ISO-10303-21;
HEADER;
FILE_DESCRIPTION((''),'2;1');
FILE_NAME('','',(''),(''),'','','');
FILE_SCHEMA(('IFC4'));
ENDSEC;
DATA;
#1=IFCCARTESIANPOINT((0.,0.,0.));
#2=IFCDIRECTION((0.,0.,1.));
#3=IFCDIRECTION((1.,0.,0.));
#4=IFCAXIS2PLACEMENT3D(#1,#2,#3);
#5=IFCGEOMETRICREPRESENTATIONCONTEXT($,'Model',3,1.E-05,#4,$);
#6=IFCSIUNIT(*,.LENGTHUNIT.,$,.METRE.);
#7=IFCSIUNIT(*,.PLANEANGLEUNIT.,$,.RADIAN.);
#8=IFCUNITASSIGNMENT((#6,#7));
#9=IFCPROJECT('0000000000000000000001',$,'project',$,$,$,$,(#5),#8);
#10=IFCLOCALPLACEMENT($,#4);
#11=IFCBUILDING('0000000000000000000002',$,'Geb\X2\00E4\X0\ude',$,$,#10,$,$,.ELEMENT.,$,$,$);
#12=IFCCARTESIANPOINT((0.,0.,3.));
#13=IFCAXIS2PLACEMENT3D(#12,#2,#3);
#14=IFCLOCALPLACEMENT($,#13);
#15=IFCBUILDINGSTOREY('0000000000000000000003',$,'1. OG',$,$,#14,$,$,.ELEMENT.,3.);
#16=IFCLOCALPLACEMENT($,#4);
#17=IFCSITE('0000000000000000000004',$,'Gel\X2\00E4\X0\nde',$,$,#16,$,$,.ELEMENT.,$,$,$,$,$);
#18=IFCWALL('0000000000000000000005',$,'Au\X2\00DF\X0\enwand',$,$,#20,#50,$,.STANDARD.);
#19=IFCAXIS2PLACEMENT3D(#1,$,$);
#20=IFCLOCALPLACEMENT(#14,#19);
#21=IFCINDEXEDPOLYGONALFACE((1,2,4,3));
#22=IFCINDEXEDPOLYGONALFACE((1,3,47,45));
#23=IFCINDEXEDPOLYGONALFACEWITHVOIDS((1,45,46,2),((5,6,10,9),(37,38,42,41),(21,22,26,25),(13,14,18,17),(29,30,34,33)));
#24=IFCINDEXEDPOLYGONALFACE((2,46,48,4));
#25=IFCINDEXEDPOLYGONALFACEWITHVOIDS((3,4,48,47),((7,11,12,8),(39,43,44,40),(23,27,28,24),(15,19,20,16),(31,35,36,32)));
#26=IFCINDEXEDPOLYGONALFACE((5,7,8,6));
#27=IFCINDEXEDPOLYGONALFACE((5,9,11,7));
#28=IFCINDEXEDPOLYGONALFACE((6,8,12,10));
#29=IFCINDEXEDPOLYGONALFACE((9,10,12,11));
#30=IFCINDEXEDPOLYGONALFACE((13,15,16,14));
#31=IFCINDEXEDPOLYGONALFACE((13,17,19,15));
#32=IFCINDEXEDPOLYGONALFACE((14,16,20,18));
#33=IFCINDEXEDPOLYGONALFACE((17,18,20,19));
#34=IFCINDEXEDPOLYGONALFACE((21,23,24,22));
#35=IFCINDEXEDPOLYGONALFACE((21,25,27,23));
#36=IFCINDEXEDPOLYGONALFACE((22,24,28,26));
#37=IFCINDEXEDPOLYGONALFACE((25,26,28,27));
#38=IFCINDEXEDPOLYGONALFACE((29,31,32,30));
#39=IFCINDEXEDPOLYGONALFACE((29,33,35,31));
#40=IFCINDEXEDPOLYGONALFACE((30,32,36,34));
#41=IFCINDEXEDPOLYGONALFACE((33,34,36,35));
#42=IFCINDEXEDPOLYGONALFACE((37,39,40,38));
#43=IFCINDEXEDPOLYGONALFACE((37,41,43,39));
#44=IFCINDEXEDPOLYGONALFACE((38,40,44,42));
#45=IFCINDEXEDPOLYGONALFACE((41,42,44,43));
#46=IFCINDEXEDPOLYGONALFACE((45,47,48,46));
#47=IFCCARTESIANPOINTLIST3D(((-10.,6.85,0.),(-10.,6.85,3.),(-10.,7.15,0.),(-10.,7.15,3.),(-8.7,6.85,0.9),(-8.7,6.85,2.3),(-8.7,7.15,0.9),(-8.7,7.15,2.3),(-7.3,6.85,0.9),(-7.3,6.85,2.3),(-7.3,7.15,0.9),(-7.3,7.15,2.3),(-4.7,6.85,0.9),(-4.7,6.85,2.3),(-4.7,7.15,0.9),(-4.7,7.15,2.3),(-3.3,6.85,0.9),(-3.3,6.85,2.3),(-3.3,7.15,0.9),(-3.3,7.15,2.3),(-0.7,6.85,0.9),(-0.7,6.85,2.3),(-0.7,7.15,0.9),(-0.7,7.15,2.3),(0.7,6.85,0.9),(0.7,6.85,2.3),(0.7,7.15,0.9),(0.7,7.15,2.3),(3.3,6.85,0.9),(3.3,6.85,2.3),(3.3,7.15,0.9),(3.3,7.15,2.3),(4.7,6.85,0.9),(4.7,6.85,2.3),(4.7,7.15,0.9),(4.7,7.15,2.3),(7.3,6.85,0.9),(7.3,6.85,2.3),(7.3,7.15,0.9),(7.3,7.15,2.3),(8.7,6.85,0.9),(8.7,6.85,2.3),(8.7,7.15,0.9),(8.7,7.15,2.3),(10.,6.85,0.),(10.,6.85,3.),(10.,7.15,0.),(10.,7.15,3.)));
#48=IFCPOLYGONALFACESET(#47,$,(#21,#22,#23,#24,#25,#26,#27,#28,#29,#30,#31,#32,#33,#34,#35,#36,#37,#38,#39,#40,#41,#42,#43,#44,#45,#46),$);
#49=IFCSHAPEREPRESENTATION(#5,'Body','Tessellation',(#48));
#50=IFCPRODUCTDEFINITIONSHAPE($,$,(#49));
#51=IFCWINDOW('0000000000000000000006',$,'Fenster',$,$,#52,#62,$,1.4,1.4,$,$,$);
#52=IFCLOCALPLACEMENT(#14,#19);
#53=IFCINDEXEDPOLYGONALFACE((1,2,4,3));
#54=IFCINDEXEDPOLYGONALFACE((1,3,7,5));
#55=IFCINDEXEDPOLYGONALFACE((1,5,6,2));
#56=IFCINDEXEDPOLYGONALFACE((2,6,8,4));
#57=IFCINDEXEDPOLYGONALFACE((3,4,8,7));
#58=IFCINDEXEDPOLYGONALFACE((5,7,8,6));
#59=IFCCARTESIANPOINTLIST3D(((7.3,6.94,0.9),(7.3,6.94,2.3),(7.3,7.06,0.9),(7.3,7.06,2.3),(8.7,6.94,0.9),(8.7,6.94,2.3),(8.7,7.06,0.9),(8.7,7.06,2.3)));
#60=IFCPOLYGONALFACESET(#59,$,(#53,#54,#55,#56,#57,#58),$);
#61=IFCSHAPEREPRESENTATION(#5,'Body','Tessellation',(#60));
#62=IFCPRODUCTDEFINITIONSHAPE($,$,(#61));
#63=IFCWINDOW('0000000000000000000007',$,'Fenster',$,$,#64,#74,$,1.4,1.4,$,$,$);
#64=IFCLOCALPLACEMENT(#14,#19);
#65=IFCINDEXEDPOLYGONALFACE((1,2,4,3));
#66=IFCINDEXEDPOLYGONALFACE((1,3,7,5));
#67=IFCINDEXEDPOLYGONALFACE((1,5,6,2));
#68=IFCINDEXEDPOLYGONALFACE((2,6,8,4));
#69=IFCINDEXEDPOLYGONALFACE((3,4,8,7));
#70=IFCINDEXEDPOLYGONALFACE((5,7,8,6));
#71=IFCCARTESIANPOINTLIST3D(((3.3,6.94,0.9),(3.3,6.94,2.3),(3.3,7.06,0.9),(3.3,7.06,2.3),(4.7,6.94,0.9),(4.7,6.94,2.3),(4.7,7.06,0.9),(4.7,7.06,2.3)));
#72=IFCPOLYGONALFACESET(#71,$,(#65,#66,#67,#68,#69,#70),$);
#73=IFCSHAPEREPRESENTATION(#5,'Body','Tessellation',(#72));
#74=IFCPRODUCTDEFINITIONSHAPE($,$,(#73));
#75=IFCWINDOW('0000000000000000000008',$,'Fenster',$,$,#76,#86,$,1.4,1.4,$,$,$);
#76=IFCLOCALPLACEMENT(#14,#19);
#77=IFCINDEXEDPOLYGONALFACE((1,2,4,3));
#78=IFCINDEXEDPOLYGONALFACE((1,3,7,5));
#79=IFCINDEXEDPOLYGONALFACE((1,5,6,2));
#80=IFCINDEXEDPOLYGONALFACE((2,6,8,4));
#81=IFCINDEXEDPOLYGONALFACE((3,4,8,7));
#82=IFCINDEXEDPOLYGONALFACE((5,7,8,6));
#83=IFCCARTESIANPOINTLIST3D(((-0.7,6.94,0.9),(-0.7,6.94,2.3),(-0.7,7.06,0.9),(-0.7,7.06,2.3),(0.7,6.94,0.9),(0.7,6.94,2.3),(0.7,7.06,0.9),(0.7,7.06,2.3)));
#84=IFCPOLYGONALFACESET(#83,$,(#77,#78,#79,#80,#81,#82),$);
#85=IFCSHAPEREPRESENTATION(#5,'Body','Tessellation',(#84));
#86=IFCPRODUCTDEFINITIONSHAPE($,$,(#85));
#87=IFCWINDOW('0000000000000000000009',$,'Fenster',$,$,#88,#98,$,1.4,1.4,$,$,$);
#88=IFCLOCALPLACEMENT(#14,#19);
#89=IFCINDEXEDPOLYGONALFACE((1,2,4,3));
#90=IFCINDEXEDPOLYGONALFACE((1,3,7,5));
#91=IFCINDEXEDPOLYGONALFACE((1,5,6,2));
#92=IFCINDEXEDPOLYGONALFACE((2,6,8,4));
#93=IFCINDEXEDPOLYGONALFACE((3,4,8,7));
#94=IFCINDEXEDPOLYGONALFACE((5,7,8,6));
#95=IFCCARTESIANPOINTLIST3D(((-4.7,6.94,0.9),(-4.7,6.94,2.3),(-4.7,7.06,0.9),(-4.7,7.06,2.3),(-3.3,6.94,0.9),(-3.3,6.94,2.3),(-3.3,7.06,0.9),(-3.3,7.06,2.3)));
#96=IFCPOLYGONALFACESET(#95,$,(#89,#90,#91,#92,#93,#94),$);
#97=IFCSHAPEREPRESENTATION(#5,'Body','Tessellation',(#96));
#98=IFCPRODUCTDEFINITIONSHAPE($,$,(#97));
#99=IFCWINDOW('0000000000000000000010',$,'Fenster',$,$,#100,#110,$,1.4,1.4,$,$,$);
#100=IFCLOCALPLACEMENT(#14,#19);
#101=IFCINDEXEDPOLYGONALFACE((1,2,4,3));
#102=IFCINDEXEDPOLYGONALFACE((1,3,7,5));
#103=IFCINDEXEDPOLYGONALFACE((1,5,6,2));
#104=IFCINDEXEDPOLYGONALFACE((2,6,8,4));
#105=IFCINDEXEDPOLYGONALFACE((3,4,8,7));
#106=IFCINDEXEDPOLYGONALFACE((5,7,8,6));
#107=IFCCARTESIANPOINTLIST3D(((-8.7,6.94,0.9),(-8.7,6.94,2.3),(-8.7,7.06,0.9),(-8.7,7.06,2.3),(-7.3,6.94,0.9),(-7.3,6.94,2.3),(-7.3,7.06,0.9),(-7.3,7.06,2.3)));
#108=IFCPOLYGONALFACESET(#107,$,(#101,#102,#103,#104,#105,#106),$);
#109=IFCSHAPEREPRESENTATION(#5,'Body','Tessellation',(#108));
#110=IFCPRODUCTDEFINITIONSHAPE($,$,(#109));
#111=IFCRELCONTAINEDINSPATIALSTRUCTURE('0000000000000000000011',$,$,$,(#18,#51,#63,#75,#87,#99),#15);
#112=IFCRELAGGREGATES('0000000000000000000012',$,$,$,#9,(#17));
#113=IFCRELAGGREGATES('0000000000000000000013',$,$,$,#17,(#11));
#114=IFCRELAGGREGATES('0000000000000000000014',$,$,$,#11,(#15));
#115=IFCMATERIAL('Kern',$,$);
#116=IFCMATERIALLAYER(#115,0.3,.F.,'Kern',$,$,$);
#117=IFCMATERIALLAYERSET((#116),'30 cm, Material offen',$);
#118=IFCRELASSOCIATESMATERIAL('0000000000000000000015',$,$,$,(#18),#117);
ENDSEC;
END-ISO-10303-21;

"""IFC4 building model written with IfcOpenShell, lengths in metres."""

from ifc_helpers import new_model, si_unit, frame, origin_with_axes, origin_2d, place, context, project, spatial, rectangle, extrude, material, layer, layer_set, element, fill, save


model = new_model("IFC4")

# Units and contexts
model_context = context("Model", 3, precision=1e-05, world=origin_with_axes())
ifc_project = project(units=[si_unit("LENGTHUNIT", "METRE"), si_unit("PLANEANGLEUNIT", "RADIAN")], contexts=[model_context])

# Site, building, storey
site_placement = place(None, origin_with_axes())
site = spatial("IfcSite", under=ifc_project, at=site_placement, Name="Gelände", CompositionType="ELEMENT")
building_placement = place(None, origin_with_axes())
building = spatial("IfcBuilding", under=site, at=building_placement, Name="Gebäude", CompositionType="ELEMENT")
storey_placement = place(None, frame((0.0, 0.0, 3.0), z_axis=(0.0, 0.0, 1.0), x_axis=(1.0, 0.0, 0.0)))
storey = spatial("IfcBuildingStorey", under=building, at=storey_placement, Name="1. OG", CompositionType="ELEMENT", Elevation=3.0)

# Wall, openings, windows
ifc_material = material(Name="Kern")
ifc_layer = layer(ifc_material, 0.3, ventilated=False, Name="Kern")
ifc_layer_set = layer_set([ifc_layer], Name="30 cm, Material offen")
wall_1_placement = place(None, frame((0.0, 7.0, 3.0), z_axis=(0.0, 0.0, 1.0), x_axis=(-1.0, 0.0, 0.0)))
wall_1 = element("IfcWall", 1, at=wall_1_placement, inside=storey, material=ifc_layer_set, Name="Außenwand", PredefinedType="STANDARD", context=model_context, shape_type="SweptSolid", body=[
    extrude(rectangle(XDim=20.0, YDim=0.3, at=origin_2d()), origin_with_axes(), (0.0, 0.0, 1.0), 3.0),
])
opening_1_placement = place(wall_1_placement, frame((-8.0, 0.0, 0.9), z_axis=(0.0, 0.0, 1.0), x_axis=(1.0, 0.0, 0.0)))
opening_1 = element("IfcOpeningElement", 2, at=opening_1_placement, cuts=wall_1, PredefinedType="OPENING", context=model_context, shape_type="SweptSolid", body=[
    extrude(rectangle(XDim=1.4, YDim=0.34, at=origin_2d()), origin_with_axes(), (0.0, 0.0, 1.0), 1.4),
])
opening_2_placement = place(wall_1_placement, frame((-4.0, 0.0, 0.9), z_axis=(0.0, 0.0, 1.0), x_axis=(1.0, 0.0, 0.0)))
opening_2 = element("IfcOpeningElement", 3, at=opening_2_placement, cuts=wall_1, PredefinedType="OPENING", context=model_context, shape_type="SweptSolid", body=[
    extrude(rectangle(XDim=1.4, YDim=0.34, at=origin_2d()), origin_with_axes(), (0.0, 0.0, 1.0), 1.4),
])
opening_3_placement = place(wall_1_placement, frame((0.0, 0.0, 0.9), z_axis=(0.0, 0.0, 1.0), x_axis=(1.0, 0.0, 0.0)))
opening_3 = element("IfcOpeningElement", 4, at=opening_3_placement, cuts=wall_1, PredefinedType="OPENING", context=model_context, shape_type="SweptSolid", body=[
    extrude(rectangle(XDim=1.4, YDim=0.34, at=origin_2d()), origin_with_axes(), (0.0, 0.0, 1.0), 1.4),
])
opening_4_placement = place(wall_1_placement, frame((4.0, 0.0, 0.9), z_axis=(0.0, 0.0, 1.0), x_axis=(1.0, 0.0, 0.0)))
opening_4 = element("IfcOpeningElement", 5, at=opening_4_placement, cuts=wall_1, PredefinedType="OPENING", context=model_context, shape_type="SweptSolid", body=[
    extrude(rectangle(XDim=1.4, YDim=0.34, at=origin_2d()), origin_with_axes(), (0.0, 0.0, 1.0), 1.4),
])
opening_5_placement = place(wall_1_placement, frame((8.0, 0.0, 0.9), z_axis=(0.0, 0.0, 1.0), x_axis=(1.0, 0.0, 0.0)))
opening_5 = element("IfcOpeningElement", 6, at=opening_5_placement, cuts=wall_1, PredefinedType="OPENING", context=model_context, shape_type="SweptSolid", body=[
    extrude(rectangle(XDim=1.4, YDim=0.34, at=origin_2d()), origin_with_axes(), (0.0, 0.0, 1.0), 1.4),
])
window_1_placement = place(opening_1_placement, origin_with_axes())
window_1 = element("IfcWindow", 7, at=window_1_placement, inside=storey, Name="Fenster", OverallHeight=1.4, OverallWidth=1.4, context=model_context, shape_type="SweptSolid", body=[
    extrude(rectangle(XDim=1.4, YDim=0.12, at=origin_2d()), origin_with_axes(), (0.0, 0.0, 1.0), 1.4),
])
fill(opening_1, window_1)
window_2_placement = place(opening_2_placement, origin_with_axes())
window_2 = element("IfcWindow", 8, at=window_2_placement, inside=storey, Name="Fenster", OverallHeight=1.4, OverallWidth=1.4, context=model_context, shape_type="SweptSolid", body=[
    extrude(rectangle(XDim=1.4, YDim=0.12, at=origin_2d()), origin_with_axes(), (0.0, 0.0, 1.0), 1.4),
])
fill(opening_2, window_2)
window_3_placement = place(opening_3_placement, origin_with_axes())
window_3 = element("IfcWindow", 9, at=window_3_placement, inside=storey, Name="Fenster", OverallHeight=1.4, OverallWidth=1.4, context=model_context, shape_type="SweptSolid", body=[
    extrude(rectangle(XDim=1.4, YDim=0.12, at=origin_2d()), origin_with_axes(), (0.0, 0.0, 1.0), 1.4),
])
fill(opening_3, window_3)
window_4_placement = place(opening_4_placement, origin_with_axes())
window_4 = element("IfcWindow", 10, at=window_4_placement, inside=storey, Name="Fenster", OverallHeight=1.4, OverallWidth=1.4, context=model_context, shape_type="SweptSolid", body=[
    extrude(rectangle(XDim=1.4, YDim=0.12, at=origin_2d()), origin_with_axes(), (0.0, 0.0, 1.0), 1.4),
])
fill(opening_4, window_4)
window_5_placement = place(opening_5_placement, origin_with_axes())
window_5 = element("IfcWindow", 11, at=window_5_placement, inside=storey, Name="Fenster", OverallHeight=1.4, OverallWidth=1.4, context=model_context, shape_type="SweptSolid", body=[
    extrude(rectangle(XDim=1.4, YDim=0.12, at=origin_2d()), origin_with_axes(), (0.0, 0.0, 1.0), 1.4),
])
fill(opening_5, window_5)

save(model, "model.ifc")
